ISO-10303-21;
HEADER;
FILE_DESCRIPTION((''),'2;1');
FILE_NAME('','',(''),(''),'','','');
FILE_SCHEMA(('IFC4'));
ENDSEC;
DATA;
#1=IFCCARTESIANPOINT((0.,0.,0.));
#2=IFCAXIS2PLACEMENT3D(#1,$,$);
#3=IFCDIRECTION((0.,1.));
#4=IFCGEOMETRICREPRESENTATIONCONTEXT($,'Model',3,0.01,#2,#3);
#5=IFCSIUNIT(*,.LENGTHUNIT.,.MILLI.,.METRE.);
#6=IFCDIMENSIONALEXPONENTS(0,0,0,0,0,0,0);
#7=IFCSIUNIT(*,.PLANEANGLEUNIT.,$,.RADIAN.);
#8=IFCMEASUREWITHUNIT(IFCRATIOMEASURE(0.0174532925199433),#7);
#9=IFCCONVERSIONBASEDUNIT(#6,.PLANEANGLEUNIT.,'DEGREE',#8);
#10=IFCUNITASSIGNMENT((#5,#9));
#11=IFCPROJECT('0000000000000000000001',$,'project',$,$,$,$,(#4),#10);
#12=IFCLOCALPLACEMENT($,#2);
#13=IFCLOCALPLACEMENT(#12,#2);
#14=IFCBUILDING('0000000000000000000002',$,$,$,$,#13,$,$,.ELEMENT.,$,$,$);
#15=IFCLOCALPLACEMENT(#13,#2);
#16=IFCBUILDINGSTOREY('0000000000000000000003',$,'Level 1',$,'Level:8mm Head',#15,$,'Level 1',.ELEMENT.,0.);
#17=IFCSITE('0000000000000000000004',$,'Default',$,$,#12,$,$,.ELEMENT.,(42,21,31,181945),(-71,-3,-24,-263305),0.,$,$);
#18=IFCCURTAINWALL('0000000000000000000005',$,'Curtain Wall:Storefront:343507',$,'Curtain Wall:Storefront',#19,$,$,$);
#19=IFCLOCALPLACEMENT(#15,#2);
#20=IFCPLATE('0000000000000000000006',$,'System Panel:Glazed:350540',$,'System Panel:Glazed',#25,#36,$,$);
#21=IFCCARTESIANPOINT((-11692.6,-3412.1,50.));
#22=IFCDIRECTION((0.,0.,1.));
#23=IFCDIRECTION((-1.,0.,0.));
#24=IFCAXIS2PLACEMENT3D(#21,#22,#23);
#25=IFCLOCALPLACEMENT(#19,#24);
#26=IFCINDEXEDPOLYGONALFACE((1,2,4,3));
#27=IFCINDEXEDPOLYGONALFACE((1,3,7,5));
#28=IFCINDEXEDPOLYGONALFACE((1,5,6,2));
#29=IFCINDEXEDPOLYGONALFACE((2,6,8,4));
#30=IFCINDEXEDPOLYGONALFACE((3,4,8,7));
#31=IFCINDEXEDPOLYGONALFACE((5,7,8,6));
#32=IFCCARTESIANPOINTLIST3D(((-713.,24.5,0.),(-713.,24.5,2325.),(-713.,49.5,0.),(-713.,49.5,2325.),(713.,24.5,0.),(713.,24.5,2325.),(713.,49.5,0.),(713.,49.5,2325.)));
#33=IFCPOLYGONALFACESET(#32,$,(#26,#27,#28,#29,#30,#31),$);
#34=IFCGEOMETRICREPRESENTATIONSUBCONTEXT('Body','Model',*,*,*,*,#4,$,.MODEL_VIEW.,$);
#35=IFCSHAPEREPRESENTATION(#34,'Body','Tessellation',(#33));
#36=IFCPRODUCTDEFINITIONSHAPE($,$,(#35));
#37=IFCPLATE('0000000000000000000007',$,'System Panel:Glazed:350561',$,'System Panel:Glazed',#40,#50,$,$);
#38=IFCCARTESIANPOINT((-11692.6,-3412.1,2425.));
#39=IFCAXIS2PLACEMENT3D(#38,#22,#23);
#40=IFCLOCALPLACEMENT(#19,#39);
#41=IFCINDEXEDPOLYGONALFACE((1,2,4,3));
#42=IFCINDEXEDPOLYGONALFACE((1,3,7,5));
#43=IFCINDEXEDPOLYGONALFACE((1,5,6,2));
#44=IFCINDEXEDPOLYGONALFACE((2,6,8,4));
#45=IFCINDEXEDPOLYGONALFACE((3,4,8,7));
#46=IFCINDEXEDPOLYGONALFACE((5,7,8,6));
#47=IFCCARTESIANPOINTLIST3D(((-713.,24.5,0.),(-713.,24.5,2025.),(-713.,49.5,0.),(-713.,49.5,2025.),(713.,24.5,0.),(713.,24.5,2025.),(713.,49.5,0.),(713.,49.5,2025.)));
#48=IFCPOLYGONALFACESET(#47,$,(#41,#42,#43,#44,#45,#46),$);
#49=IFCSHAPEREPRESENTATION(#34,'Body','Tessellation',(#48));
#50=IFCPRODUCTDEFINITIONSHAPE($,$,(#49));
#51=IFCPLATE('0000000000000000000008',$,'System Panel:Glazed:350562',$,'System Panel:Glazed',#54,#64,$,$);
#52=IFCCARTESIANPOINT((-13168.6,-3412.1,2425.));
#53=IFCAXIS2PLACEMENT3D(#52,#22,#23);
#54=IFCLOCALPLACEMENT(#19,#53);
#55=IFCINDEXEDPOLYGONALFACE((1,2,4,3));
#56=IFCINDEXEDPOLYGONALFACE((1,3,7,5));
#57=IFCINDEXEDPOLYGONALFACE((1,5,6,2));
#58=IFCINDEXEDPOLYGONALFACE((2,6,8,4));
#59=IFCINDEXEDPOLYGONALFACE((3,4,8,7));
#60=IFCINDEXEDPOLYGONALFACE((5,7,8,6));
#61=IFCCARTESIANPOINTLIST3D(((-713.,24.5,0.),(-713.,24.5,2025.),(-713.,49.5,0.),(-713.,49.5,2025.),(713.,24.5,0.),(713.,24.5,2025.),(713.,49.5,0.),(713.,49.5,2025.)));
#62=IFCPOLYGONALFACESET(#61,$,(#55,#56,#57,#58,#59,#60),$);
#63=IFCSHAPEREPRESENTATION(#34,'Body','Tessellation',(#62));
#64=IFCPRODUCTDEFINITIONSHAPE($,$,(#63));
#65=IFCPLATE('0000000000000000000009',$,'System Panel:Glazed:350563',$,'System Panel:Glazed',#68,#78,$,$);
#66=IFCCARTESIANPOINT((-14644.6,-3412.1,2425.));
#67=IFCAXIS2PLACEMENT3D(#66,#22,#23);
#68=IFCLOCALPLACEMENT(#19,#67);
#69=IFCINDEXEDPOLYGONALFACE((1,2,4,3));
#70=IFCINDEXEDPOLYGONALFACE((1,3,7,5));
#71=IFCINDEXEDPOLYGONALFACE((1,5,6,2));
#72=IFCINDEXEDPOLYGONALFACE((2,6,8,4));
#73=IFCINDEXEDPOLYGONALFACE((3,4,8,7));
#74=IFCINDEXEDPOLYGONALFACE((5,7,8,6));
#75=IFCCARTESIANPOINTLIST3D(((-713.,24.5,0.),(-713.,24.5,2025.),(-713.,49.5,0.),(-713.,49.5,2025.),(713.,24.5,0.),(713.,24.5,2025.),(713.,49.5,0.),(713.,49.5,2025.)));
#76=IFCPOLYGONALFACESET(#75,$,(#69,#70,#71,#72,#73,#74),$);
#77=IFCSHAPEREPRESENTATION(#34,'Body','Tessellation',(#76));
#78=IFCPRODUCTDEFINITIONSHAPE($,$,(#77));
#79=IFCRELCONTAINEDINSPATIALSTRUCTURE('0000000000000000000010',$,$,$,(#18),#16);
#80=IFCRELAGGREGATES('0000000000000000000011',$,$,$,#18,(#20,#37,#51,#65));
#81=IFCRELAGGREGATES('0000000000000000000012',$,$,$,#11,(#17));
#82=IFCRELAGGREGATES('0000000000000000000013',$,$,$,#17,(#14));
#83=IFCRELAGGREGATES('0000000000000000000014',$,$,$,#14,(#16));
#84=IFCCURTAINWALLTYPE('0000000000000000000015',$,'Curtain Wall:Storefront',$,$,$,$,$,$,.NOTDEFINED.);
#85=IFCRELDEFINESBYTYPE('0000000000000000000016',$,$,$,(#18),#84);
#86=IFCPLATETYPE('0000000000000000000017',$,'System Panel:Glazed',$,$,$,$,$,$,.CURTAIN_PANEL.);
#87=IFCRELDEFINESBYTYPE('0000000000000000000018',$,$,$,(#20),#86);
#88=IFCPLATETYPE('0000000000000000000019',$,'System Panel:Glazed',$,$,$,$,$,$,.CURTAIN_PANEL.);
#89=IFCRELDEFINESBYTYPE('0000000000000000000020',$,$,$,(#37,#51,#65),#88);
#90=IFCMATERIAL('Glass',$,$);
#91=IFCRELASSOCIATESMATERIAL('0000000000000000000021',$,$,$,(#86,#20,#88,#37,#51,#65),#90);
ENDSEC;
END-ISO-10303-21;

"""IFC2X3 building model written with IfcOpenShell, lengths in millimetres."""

from ifc_helpers import new_model, entity, si_unit, converted_unit, direction, frame, origin, origin_2d_with_axis, place, context, subcontext, project, spatial, rectangle, extrude, source, transform, mapped, material, type_object, type_shapes, element, aggregate, save


model = new_model("IFC2X3")

# Units and contexts
model_context = context("Model", 3, precision=0.01, world=origin(), true_north=direction((0.0, 1.0)))
body_context = subcontext(model_context, "Body", "Model", "MODEL_VIEW")
ifc_project = project(units=[si_unit("LENGTHUNIT", "METRE", prefix="MILLI"), converted_unit("PLANEANGLEUNIT", "DEGREE", entity("IfcRatioMeasure", 0.0174532925199433), si_unit("PLANEANGLEUNIT", "RADIAN"), dimensions=[0, 0, 0, 0, 0, 0, 0])], contexts=[model_context])

# Site, building, storey
site_placement = place(None, frame((0.0, 0.0, 0.0)))
site = spatial("IfcSite", under=ifc_project, at=site_placement, Name="Default", CompositionType="ELEMENT", RefLatitude=(42, 21, 31, 181945), RefLongitude=(-71, -3, -24, -263305), RefElevation=0.0)
building_placement = place(site_placement, origin())
building = spatial("IfcBuilding", under=site, at=building_placement, CompositionType="ELEMENT")
storey_placement = place(building_placement, origin())
storey = spatial("IfcBuildingStorey", under=building, at=storey_placement, Name="Level 1", ObjectType="Level:8mm Head", LongName="Level 1", CompositionType="ELEMENT", Elevation=0.0)

# Curtain wall, plates
curtain_wall_type = type_object("IfcCurtainWallType", Name="Curtain Wall:Storefront", PredefinedType="NOTDEFINED")
curtain_wall_placement = place(storey_placement, origin())
curtain_wall = element("IfcCurtainWall", 1, at=curtain_wall_placement, inside=storey, type_object=curtain_wall_type, Name="Curtain Wall:Storefront:343507", ObjectType="Curtain Wall:Storefront")
ifc_material_1 = material(Name="Glass")
plate_type_1 = type_object("IfcPlateType", Name="System Panel:Glazed", PredefinedType="CURTAIN_PANEL", material=ifc_material_1)
shared_shape_1 = source(origin(), body_context, "Body", "SweptSolid", [
    extrude(rectangle(XDim=25.0, YDim=1426.0, at=origin_2d_with_axis()), frame((0.0, 37.0, 0.0), z_axis=(0.0, 0.0, 1.0), x_axis=(0.0, 1.0, 0.0)), (0.0, 0.0, 1.0), 2325.0),
])
type_shapes(plate_type_1, [shared_shape_1])
plate_1_placement = place(curtain_wall_placement, frame((-11692.6, -3412.1, 50.0), z_axis=(0.0, 0.0, 1.0), x_axis=(-1.0, 0.0, 0.0)))
plate_1 = element("IfcPlate", 2, at=plate_1_placement, type_object=plate_type_1, material=ifc_material_1, Name="System Panel:Glazed:350540", ObjectType="System Panel:Glazed", context=body_context, shape_type="MappedRepresentation", body=[
    mapped(shared_shape_1, transform((0.0, 0.0, 0.0), scale=1.0)),
])
plate_type_2 = type_object("IfcPlateType", Name="System Panel:Glazed", PredefinedType="CURTAIN_PANEL", material=ifc_material_1)
shared_shape_2 = source(origin(), body_context, "Body", "SweptSolid", [
    extrude(rectangle(XDim=25.0, YDim=1426.0, at=origin_2d_with_axis()), frame((0.0, 37.0, 0.0), z_axis=(0.0, 0.0, 1.0), x_axis=(0.0, 1.0, 0.0)), (0.0, 0.0, 1.0), 2025.0),
])
type_shapes(plate_type_2, [shared_shape_2])
plate_2_placement = place(curtain_wall_placement, frame((-11692.6, -3412.1, 2425.0), z_axis=(0.0, 0.0, 1.0), x_axis=(-1.0, 0.0, 0.0)))
plate_2 = element("IfcPlate", 3, at=plate_2_placement, type_object=plate_type_2, material=ifc_material_1, Name="System Panel:Glazed:350561", ObjectType="System Panel:Glazed", context=body_context, shape_type="MappedRepresentation", body=[
    mapped(shared_shape_2, transform((0.0, 0.0, 0.0), scale=1.0)),
])
plate_3_placement = place(curtain_wall_placement, frame((-13168.6, -3412.1, 2425.0), z_axis=(0.0, 0.0, 1.0), x_axis=(-1.0, 0.0, 0.0)))
plate_3 = element("IfcPlate", 4, at=plate_3_placement, type_object=plate_type_2, material=ifc_material_1, Name="System Panel:Glazed:350562", ObjectType="System Panel:Glazed", context=body_context, shape_type="MappedRepresentation", body=[
    mapped(shared_shape_2, transform((0.0, 0.0, 0.0), scale=1.0)),
])
plate_4_placement = place(curtain_wall_placement, frame((-14644.6, -3412.1, 2425.0), z_axis=(0.0, 0.0, 1.0), x_axis=(-1.0, 0.0, 0.0)))
plate_4 = element("IfcPlate", 5, at=plate_4_placement, type_object=plate_type_2, material=ifc_material_1, Name="System Panel:Glazed:350563", ObjectType="System Panel:Glazed", context=body_context, shape_type="MappedRepresentation", body=[
    mapped(shared_shape_2, transform((0.0, 0.0, 0.0), scale=1.0)),
])
aggregate(curtain_wall, [plate_1, plate_2, plate_3, plate_4])

save(model, "model.ifc")
